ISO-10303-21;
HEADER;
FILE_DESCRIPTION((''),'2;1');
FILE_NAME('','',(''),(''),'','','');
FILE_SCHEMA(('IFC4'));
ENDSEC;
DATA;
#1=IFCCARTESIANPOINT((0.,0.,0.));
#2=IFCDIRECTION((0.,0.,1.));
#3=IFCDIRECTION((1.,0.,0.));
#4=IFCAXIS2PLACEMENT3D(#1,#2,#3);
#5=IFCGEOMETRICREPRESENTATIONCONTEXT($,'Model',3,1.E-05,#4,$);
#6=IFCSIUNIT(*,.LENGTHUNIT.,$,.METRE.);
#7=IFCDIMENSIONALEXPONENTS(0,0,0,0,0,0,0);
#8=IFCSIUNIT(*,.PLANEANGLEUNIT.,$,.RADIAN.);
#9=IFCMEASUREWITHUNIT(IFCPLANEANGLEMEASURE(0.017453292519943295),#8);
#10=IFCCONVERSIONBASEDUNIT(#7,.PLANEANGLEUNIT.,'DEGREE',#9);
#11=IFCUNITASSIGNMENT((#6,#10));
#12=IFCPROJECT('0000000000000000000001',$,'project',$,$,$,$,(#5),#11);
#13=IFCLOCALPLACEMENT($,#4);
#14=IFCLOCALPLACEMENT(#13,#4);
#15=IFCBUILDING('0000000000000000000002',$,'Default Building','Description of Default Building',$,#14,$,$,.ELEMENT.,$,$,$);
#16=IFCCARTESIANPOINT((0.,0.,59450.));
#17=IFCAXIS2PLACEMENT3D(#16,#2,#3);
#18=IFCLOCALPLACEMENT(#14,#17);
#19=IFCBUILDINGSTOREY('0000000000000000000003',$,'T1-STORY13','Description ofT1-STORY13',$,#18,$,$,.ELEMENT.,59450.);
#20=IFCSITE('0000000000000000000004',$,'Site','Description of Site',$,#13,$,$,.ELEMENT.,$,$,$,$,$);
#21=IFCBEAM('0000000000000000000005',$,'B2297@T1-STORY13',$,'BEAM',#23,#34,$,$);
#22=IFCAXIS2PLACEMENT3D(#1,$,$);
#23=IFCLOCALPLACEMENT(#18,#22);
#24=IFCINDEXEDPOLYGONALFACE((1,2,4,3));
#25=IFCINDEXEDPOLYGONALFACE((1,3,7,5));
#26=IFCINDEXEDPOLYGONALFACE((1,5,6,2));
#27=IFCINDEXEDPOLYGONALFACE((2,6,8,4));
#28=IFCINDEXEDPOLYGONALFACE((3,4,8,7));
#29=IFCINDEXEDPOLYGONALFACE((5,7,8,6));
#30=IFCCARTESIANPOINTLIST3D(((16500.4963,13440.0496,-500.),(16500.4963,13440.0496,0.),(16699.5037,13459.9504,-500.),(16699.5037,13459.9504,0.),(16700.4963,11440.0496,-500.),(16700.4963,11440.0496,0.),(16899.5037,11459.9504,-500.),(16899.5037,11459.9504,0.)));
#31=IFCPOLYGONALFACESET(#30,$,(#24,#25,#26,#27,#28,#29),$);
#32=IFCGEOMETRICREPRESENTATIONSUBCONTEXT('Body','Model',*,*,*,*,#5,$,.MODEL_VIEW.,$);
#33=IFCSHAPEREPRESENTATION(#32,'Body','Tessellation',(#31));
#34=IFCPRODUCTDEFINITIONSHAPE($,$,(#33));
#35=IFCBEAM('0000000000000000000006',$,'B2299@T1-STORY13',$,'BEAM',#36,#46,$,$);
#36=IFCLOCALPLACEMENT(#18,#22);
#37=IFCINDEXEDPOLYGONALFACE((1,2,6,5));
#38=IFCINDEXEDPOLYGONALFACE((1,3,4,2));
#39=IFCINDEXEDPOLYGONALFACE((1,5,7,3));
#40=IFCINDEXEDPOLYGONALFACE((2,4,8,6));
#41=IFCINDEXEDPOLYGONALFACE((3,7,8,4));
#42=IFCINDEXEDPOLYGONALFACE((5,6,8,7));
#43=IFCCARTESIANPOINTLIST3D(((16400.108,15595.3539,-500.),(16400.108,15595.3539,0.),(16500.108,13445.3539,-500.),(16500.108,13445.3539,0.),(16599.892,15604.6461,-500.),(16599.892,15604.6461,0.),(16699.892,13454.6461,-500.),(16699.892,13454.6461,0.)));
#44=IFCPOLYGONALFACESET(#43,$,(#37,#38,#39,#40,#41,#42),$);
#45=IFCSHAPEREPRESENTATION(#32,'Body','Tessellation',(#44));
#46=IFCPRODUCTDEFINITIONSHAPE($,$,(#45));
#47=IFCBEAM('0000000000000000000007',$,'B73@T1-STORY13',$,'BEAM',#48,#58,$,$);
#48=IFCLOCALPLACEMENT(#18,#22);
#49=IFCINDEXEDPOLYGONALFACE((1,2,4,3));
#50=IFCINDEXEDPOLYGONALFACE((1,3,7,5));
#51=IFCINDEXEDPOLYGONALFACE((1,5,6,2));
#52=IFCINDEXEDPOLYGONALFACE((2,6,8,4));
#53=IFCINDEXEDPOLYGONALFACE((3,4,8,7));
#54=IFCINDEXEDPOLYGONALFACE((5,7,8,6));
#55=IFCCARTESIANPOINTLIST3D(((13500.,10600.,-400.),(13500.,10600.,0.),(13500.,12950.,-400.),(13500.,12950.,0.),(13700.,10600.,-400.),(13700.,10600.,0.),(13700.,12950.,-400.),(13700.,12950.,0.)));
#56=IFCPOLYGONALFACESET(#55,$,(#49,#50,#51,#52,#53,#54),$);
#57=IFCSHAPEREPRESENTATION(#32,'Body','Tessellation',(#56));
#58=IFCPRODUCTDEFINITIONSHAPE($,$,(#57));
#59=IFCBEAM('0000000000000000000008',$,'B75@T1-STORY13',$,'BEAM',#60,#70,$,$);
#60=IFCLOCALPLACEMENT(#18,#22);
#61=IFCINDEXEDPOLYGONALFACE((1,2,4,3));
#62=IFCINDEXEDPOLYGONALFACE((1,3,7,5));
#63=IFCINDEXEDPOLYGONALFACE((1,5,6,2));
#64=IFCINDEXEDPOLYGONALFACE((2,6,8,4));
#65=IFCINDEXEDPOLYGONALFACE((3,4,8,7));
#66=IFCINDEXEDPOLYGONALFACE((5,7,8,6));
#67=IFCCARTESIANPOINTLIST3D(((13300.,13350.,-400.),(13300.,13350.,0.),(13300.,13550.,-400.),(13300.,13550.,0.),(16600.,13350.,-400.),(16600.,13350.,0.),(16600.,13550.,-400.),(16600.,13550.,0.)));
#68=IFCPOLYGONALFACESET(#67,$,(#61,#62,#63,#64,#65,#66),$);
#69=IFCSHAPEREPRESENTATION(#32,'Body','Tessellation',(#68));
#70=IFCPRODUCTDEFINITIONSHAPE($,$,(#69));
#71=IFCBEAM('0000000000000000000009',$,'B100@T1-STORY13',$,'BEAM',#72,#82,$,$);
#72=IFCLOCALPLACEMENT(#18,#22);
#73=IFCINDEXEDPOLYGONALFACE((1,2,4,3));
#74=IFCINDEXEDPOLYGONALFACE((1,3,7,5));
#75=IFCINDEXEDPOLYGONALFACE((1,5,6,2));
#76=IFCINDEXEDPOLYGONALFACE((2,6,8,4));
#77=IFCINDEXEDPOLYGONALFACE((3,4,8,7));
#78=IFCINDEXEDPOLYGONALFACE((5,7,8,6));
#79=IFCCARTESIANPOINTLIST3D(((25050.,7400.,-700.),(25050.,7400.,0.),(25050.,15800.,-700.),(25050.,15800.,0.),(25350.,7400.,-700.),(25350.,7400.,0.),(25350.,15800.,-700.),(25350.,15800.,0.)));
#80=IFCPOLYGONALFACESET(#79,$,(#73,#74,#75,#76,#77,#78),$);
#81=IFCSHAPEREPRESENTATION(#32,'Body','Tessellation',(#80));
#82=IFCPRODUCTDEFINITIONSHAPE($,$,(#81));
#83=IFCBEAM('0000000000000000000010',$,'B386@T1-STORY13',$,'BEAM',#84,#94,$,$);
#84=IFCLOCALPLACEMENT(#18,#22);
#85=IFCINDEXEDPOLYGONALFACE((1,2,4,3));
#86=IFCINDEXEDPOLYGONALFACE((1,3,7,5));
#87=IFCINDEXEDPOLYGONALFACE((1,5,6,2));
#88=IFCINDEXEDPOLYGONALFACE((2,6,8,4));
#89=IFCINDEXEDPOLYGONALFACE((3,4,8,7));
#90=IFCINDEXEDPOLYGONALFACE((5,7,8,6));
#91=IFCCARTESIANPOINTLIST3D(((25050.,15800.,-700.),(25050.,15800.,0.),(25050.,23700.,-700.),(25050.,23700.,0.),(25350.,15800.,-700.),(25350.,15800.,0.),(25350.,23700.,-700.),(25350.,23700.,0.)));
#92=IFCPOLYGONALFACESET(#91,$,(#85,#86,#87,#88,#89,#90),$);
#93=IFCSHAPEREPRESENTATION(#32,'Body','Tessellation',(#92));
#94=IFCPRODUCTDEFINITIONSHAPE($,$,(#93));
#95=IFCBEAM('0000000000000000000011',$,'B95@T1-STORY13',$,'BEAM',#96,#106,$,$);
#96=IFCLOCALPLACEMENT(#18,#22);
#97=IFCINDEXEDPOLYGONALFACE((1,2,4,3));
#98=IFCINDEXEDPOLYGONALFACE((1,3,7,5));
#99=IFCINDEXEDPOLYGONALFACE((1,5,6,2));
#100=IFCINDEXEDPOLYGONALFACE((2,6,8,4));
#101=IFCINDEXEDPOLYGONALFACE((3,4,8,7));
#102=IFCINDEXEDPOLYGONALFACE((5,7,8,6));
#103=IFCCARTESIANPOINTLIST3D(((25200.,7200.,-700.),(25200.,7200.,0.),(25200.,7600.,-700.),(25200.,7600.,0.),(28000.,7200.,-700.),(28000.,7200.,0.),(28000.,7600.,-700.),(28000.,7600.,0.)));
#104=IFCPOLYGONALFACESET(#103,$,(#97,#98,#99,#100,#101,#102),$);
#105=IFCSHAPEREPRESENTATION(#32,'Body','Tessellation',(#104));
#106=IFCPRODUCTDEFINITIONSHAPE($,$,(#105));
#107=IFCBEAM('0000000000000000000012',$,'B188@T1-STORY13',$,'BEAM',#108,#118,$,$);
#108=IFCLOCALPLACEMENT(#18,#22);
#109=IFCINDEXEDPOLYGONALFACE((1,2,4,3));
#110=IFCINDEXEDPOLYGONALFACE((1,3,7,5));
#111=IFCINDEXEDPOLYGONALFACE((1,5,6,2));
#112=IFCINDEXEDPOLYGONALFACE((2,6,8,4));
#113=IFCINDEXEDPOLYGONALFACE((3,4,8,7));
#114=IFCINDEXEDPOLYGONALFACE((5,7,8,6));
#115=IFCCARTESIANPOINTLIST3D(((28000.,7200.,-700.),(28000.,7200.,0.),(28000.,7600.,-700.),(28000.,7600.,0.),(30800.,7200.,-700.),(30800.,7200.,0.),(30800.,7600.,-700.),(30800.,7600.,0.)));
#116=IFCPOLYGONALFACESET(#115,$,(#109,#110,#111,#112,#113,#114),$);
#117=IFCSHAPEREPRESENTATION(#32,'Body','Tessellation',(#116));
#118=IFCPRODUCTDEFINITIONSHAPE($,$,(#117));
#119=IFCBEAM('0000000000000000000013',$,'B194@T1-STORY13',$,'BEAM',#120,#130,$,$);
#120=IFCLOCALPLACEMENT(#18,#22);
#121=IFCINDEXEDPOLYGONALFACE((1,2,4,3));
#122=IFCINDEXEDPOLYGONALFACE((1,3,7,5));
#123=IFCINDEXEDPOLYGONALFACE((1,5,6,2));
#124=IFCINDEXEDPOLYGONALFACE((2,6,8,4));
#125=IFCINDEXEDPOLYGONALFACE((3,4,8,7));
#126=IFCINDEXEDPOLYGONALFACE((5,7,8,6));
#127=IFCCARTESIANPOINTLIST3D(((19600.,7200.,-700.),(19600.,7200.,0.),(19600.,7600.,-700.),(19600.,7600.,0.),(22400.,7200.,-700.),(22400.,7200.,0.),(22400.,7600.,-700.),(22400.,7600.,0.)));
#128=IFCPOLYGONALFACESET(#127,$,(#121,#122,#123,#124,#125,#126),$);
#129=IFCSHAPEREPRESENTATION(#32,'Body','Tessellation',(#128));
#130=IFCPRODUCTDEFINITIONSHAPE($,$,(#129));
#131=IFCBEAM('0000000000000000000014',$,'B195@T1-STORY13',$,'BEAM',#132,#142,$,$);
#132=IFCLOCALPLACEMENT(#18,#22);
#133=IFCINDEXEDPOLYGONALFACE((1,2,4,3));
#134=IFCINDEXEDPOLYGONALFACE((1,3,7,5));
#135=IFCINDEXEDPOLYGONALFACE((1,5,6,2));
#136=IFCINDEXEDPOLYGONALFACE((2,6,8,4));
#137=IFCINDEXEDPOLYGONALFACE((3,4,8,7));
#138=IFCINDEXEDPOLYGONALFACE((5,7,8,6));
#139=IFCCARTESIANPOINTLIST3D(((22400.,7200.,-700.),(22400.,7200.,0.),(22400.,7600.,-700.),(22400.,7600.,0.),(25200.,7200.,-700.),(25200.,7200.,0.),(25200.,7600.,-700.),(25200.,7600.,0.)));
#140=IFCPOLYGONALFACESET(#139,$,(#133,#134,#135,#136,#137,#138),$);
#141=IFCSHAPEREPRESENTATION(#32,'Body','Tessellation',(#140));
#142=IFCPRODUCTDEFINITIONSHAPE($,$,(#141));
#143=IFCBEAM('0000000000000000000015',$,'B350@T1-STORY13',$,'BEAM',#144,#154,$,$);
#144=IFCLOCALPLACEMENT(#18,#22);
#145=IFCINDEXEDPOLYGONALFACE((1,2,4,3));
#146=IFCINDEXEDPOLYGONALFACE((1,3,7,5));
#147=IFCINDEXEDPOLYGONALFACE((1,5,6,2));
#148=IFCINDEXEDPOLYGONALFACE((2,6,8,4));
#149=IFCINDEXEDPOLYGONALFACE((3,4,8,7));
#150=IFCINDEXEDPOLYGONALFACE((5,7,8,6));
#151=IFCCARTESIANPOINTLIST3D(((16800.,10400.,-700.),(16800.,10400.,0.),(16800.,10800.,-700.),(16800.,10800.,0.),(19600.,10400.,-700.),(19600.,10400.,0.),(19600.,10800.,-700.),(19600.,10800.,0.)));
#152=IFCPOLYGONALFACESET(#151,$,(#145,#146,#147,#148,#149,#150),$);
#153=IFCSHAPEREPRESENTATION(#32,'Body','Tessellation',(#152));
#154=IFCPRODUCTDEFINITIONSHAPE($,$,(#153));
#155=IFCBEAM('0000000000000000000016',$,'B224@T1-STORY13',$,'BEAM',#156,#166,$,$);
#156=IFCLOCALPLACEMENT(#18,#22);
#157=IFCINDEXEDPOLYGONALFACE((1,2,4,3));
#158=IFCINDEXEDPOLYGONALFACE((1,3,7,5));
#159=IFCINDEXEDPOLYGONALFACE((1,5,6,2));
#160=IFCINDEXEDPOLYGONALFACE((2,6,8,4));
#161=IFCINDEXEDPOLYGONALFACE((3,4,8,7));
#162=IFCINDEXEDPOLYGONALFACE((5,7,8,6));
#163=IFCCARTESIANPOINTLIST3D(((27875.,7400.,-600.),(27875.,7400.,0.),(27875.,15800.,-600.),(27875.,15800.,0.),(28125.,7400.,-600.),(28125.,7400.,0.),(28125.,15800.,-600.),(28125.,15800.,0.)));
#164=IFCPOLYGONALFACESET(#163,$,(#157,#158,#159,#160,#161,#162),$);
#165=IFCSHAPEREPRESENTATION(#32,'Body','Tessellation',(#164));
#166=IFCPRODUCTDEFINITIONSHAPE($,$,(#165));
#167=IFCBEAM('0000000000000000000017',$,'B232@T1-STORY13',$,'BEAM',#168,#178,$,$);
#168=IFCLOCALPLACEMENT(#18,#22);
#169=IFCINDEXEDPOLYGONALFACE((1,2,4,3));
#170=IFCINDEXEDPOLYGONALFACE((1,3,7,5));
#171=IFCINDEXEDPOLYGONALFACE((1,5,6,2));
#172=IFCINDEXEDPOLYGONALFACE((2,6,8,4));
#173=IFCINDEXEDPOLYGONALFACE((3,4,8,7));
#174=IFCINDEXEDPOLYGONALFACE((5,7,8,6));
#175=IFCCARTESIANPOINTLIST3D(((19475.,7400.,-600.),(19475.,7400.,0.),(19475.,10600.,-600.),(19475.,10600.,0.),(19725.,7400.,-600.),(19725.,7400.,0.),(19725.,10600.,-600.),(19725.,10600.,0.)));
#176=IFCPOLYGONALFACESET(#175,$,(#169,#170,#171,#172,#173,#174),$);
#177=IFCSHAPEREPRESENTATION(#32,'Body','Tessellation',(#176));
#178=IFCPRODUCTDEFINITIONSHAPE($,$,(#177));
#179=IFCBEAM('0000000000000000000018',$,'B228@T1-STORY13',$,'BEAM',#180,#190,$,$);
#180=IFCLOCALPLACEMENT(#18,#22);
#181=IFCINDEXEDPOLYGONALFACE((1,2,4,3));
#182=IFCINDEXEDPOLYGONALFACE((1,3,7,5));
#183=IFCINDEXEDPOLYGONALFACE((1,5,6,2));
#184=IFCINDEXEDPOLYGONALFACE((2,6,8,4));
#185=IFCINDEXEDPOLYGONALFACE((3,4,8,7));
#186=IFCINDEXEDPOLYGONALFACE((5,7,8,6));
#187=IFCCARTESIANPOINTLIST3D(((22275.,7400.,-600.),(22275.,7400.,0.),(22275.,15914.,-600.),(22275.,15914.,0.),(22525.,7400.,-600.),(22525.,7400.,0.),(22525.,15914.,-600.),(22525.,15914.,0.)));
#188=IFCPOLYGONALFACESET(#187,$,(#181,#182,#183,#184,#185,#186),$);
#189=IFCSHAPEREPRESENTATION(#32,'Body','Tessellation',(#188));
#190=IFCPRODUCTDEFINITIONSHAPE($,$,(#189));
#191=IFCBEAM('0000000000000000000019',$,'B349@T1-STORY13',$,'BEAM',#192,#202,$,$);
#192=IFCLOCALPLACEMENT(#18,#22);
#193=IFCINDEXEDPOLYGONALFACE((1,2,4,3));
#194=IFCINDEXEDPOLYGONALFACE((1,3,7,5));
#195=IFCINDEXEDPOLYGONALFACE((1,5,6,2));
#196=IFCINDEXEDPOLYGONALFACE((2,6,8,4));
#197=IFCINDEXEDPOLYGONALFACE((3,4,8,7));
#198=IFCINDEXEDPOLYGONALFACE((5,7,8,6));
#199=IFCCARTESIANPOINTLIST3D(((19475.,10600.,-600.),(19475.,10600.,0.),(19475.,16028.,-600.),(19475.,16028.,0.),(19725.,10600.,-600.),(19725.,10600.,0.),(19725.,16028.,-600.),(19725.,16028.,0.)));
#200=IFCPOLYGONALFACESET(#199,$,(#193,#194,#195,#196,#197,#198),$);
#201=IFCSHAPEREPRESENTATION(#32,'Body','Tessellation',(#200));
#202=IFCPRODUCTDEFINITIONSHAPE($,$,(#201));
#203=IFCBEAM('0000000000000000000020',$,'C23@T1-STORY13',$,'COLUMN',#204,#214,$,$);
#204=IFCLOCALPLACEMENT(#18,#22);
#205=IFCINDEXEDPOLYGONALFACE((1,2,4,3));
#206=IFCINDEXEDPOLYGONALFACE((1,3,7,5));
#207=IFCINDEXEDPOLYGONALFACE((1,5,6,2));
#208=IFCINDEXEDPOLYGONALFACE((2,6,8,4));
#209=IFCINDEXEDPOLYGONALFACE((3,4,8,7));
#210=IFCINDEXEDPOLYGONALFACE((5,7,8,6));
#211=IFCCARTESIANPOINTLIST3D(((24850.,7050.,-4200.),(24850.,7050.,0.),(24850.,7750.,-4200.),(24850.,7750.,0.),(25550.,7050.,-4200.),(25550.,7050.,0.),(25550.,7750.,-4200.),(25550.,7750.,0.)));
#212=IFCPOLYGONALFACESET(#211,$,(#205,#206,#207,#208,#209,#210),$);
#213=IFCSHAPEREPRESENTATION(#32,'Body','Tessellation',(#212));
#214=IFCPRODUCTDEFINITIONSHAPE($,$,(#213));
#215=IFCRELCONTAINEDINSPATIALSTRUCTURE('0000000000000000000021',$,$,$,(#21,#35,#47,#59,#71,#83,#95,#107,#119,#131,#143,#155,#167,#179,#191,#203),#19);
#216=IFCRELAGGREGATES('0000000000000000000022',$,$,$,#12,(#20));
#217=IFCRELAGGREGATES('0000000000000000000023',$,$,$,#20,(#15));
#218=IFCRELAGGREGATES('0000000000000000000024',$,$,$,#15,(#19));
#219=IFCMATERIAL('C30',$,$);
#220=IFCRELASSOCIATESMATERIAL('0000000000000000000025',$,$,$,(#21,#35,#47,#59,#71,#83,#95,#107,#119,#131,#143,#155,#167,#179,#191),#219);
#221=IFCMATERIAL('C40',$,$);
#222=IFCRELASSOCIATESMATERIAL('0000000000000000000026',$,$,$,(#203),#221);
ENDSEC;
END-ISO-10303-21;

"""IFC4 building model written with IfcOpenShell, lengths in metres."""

from ifc_helpers import new_model, entity, si_unit, converted_unit, frame, origin_with_axes, place, context, subcontext, project, spatial, rectangle, extrude, material, element, save


model = new_model("IFC4")

# Units and contexts
model_context = context("Model", 3, precision=1e-05, world=origin_with_axes())
body_context = subcontext(model_context, "Body", "Model", "MODEL_VIEW")
ifc_project = project(units=[si_unit("LENGTHUNIT", "METRE"), converted_unit("PLANEANGLEUNIT", "DEGREE", entity("IfcPlaneAngleMeasure", 0.017453292519943295), si_unit("PLANEANGLEUNIT", "RADIAN"), dimensions=[0, 0, 0, 0, 0, 0, 0])], contexts=[model_context])

# Site, building, storey
site_placement = place(None, origin_with_axes())
site = spatial("IfcSite", under=ifc_project, at=site_placement, Name="Site", Description="Description of Site", CompositionType="ELEMENT")
building_placement = place(site_placement, origin_with_axes())
building = spatial("IfcBuilding", under=site, at=building_placement, Name="Default Building", Description="Description of Default Building", CompositionType="ELEMENT")
storey_placement = place(building_placement, frame((0.0, 0.0, 59450.0), z_axis=(0.0, 0.0, 1.0), x_axis=(1.0, 0.0, 0.0)))
storey = spatial("IfcBuildingStorey", under=building, at=storey_placement, Name="T1-STORY13", Description="Description ofT1-STORY13", CompositionType="ELEMENT", Elevation=59450.0)

# Beams
ifc_material_1 = material(Name="C30")
beam_1_placement = place(storey_placement, frame((16600.0, 13450.0, -250.0), z_axis=(0.099504, -0.995037, 0.0), x_axis=(0.995037, 0.099504, 0.0)))
element("IfcBeam", 1, at=beam_1_placement, inside=storey, material=ifc_material_1, Name="B2297@T1-STORY13", ObjectType="BEAM", context=body_context, shape_type="SweptSolid", body=[
    extrude(rectangle(XDim=200.0, YDim=500.0), origin_with_axes(), (0.0, 0.0, 1.0), 2009.9751),
])
beam_2_placement = place(storey_placement, frame((16500.0, 15600.0, -250.0), z_axis=(0.046461, -0.99892, 0.0), x_axis=(0.99892, 0.046461, 0.0)))
element("IfcBeam", 2, at=beam_2_placement, inside=storey, material=ifc_material_1, Name="B2299@T1-STORY13", ObjectType="BEAM", context=body_context, shape_type="SweptSolid", body=[
    extrude(rectangle(XDim=200.0, YDim=500.0), origin_with_axes(), (0.0, 0.0, 1.0), 2152.3243),
])
beam_3_placement = place(storey_placement, frame((13600.0, 10600.0, -200.0), z_axis=(0.0, 1.0, 0.0), x_axis=(-1.0, 0.0, 0.0)))
element("IfcBeam", 3, at=beam_3_placement, inside=storey, material=ifc_material_1, Name="B73@T1-STORY13", ObjectType="BEAM", context=body_context, shape_type="SweptSolid", body=[
    extrude(rectangle(XDim=200.0, YDim=400.0), origin_with_axes(), (0.0, 0.0, 1.0), 2350.0),
])
beam_4_placement = place(storey_placement, frame((13300.0, 13450.0, -200.0), z_axis=(1.0, 0.0, 0.0), x_axis=(0.0, 1.0, 0.0)))
element("IfcBeam", 4, at=beam_4_placement, inside=storey, material=ifc_material_1, Name="B75@T1-STORY13", ObjectType="BEAM", context=body_context, shape_type="SweptSolid", body=[
    extrude(rectangle(XDim=200.0, YDim=400.0), origin_with_axes(), (0.0, 0.0, 1.0), 3300.0),
])
beam_5_placement = place(storey_placement, frame((25200.0, 7400.0, -350.0), z_axis=(0.0, 1.0, 0.0), x_axis=(-1.0, 0.0, 0.0)))
element("IfcBeam", 5, at=beam_5_placement, inside=storey, material=ifc_material_1, Name="B100@T1-STORY13", ObjectType="BEAM", context=body_context, shape_type="SweptSolid", body=[
    extrude(rectangle(XDim=300.0, YDim=700.0), origin_with_axes(), (0.0, 0.0, 1.0), 8400.0),
])
beam_6_placement = place(storey_placement, frame((25200.0, 15800.0, -350.0), z_axis=(0.0, 1.0, 0.0), x_axis=(-1.0, 0.0, 0.0)))
element("IfcBeam", 6, at=beam_6_placement, inside=storey, material=ifc_material_1, Name="B386@T1-STORY13", ObjectType="BEAM", context=body_context, shape_type="SweptSolid", body=[
    extrude(rectangle(XDim=300.0, YDim=700.0), origin_with_axes(), (0.0, 0.0, 1.0), 7900.0),
])
for number, where, z_axis, x_axis, name in (
    (7, (25200.0, 7400.0, -350.0), (1.0, 0.0, 0.0), (0.0, 1.0, 0.0), "B95@T1-STORY13"),
    (8, (28000.0, 7400.0, -350.0), (1.0, 0.0, 0.0), (0.0, 1.0, 0.0), "B188@T1-STORY13"),
    (9, (19600.0, 7400.0, -350.0), (1.0, 0.0, 0.0), (0.0, 1.0, 0.0), "B194@T1-STORY13"),
    (10, (22400.0, 7400.0, -350.0), (1.0, 0.0, 0.0), (0.0, 1.0, 0.0), "B195@T1-STORY13"),
    (11, (16800.0, 10600.0, -350.0), (1.0, 0.0, 0.0), (0.0, 1.0, 0.0), "B350@T1-STORY13"),
):
    element("IfcBeam", number, at=place(storey_placement, frame(where, z_axis=z_axis, x_axis=x_axis)), inside=storey, material=ifc_material_1, Name=name, ObjectType="BEAM", context=body_context, shape_type="SweptSolid", body=[
        extrude(rectangle(XDim=400.0, YDim=700.0), origin_with_axes(), (0.0, 0.0, 1.0), 2800.0),
    ])
beam_7_placement = place(storey_placement, frame((28000.0, 7400.0, -300.0), z_axis=(0.0, 1.0, 0.0), x_axis=(-1.0, 0.0, 0.0)))
element("IfcBeam", 12, at=beam_7_placement, inside=storey, material=ifc_material_1, Name="B224@T1-STORY13", ObjectType="BEAM", context=body_context, shape_type="SweptSolid", body=[
    extrude(rectangle(XDim=250.0, YDim=600.0), origin_with_axes(), (0.0, 0.0, 1.0), 8400.0),
])
beam_8_placement = place(storey_placement, frame((19600.0, 7400.0, -300.0), z_axis=(0.0, 1.0, 0.0), x_axis=(-1.0, 0.0, 0.0)))
element("IfcBeam", 13, at=beam_8_placement, inside=storey, material=ifc_material_1, Name="B232@T1-STORY13", ObjectType="BEAM", context=body_context, shape_type="SweptSolid", body=[
    extrude(rectangle(XDim=250.0, YDim=600.0), origin_with_axes(), (0.0, 0.0, 1.0), 3200.0),
])
beam_9_placement = place(storey_placement, frame((22400.0, 7400.0, -300.0), z_axis=(0.0, 1.0, 0.0), x_axis=(-1.0, 0.0, 0.0)))
element("IfcBeam", 14, at=beam_9_placement, inside=storey, material=ifc_material_1, Name="B228@T1-STORY13", ObjectType="BEAM", context=body_context, shape_type="SweptSolid", body=[
    extrude(rectangle(XDim=250.0, YDim=600.0), origin_with_axes(), (0.0, 0.0, 1.0), 8514.0),
])
beam_10_placement = place(storey_placement, frame((19600.0, 10600.0, -300.0), z_axis=(0.0, 1.0, 0.0), x_axis=(-1.0, 0.0, 0.0)))
element("IfcBeam", 15, at=beam_10_placement, inside=storey, material=ifc_material_1, Name="B349@T1-STORY13", ObjectType="BEAM", context=body_context, shape_type="SweptSolid", body=[
    extrude(rectangle(XDim=250.0, YDim=600.0), origin_with_axes(), (0.0, 0.0, 1.0), 5428.0),
])
ifc_material_2 = material(Name="C40")
beam_11_placement = place(storey_placement, frame((25200.0, 7400.0, -4200.0), z_axis=(0.0, 0.0, 1.0), x_axis=(-1.0, 0.0, 0.0)))
element("IfcBeam", 16, at=beam_11_placement, inside=storey, material=ifc_material_2, Name="C23@T1-STORY13", ObjectType="COLUMN", context=body_context, shape_type="SweptSolid", body=[
    extrude(rectangle(XDim=700.0, YDim=700.0), origin_with_axes(), (0.0, 0.0, 1.0), 4200.0),
])

save(model, "model.ifc")
